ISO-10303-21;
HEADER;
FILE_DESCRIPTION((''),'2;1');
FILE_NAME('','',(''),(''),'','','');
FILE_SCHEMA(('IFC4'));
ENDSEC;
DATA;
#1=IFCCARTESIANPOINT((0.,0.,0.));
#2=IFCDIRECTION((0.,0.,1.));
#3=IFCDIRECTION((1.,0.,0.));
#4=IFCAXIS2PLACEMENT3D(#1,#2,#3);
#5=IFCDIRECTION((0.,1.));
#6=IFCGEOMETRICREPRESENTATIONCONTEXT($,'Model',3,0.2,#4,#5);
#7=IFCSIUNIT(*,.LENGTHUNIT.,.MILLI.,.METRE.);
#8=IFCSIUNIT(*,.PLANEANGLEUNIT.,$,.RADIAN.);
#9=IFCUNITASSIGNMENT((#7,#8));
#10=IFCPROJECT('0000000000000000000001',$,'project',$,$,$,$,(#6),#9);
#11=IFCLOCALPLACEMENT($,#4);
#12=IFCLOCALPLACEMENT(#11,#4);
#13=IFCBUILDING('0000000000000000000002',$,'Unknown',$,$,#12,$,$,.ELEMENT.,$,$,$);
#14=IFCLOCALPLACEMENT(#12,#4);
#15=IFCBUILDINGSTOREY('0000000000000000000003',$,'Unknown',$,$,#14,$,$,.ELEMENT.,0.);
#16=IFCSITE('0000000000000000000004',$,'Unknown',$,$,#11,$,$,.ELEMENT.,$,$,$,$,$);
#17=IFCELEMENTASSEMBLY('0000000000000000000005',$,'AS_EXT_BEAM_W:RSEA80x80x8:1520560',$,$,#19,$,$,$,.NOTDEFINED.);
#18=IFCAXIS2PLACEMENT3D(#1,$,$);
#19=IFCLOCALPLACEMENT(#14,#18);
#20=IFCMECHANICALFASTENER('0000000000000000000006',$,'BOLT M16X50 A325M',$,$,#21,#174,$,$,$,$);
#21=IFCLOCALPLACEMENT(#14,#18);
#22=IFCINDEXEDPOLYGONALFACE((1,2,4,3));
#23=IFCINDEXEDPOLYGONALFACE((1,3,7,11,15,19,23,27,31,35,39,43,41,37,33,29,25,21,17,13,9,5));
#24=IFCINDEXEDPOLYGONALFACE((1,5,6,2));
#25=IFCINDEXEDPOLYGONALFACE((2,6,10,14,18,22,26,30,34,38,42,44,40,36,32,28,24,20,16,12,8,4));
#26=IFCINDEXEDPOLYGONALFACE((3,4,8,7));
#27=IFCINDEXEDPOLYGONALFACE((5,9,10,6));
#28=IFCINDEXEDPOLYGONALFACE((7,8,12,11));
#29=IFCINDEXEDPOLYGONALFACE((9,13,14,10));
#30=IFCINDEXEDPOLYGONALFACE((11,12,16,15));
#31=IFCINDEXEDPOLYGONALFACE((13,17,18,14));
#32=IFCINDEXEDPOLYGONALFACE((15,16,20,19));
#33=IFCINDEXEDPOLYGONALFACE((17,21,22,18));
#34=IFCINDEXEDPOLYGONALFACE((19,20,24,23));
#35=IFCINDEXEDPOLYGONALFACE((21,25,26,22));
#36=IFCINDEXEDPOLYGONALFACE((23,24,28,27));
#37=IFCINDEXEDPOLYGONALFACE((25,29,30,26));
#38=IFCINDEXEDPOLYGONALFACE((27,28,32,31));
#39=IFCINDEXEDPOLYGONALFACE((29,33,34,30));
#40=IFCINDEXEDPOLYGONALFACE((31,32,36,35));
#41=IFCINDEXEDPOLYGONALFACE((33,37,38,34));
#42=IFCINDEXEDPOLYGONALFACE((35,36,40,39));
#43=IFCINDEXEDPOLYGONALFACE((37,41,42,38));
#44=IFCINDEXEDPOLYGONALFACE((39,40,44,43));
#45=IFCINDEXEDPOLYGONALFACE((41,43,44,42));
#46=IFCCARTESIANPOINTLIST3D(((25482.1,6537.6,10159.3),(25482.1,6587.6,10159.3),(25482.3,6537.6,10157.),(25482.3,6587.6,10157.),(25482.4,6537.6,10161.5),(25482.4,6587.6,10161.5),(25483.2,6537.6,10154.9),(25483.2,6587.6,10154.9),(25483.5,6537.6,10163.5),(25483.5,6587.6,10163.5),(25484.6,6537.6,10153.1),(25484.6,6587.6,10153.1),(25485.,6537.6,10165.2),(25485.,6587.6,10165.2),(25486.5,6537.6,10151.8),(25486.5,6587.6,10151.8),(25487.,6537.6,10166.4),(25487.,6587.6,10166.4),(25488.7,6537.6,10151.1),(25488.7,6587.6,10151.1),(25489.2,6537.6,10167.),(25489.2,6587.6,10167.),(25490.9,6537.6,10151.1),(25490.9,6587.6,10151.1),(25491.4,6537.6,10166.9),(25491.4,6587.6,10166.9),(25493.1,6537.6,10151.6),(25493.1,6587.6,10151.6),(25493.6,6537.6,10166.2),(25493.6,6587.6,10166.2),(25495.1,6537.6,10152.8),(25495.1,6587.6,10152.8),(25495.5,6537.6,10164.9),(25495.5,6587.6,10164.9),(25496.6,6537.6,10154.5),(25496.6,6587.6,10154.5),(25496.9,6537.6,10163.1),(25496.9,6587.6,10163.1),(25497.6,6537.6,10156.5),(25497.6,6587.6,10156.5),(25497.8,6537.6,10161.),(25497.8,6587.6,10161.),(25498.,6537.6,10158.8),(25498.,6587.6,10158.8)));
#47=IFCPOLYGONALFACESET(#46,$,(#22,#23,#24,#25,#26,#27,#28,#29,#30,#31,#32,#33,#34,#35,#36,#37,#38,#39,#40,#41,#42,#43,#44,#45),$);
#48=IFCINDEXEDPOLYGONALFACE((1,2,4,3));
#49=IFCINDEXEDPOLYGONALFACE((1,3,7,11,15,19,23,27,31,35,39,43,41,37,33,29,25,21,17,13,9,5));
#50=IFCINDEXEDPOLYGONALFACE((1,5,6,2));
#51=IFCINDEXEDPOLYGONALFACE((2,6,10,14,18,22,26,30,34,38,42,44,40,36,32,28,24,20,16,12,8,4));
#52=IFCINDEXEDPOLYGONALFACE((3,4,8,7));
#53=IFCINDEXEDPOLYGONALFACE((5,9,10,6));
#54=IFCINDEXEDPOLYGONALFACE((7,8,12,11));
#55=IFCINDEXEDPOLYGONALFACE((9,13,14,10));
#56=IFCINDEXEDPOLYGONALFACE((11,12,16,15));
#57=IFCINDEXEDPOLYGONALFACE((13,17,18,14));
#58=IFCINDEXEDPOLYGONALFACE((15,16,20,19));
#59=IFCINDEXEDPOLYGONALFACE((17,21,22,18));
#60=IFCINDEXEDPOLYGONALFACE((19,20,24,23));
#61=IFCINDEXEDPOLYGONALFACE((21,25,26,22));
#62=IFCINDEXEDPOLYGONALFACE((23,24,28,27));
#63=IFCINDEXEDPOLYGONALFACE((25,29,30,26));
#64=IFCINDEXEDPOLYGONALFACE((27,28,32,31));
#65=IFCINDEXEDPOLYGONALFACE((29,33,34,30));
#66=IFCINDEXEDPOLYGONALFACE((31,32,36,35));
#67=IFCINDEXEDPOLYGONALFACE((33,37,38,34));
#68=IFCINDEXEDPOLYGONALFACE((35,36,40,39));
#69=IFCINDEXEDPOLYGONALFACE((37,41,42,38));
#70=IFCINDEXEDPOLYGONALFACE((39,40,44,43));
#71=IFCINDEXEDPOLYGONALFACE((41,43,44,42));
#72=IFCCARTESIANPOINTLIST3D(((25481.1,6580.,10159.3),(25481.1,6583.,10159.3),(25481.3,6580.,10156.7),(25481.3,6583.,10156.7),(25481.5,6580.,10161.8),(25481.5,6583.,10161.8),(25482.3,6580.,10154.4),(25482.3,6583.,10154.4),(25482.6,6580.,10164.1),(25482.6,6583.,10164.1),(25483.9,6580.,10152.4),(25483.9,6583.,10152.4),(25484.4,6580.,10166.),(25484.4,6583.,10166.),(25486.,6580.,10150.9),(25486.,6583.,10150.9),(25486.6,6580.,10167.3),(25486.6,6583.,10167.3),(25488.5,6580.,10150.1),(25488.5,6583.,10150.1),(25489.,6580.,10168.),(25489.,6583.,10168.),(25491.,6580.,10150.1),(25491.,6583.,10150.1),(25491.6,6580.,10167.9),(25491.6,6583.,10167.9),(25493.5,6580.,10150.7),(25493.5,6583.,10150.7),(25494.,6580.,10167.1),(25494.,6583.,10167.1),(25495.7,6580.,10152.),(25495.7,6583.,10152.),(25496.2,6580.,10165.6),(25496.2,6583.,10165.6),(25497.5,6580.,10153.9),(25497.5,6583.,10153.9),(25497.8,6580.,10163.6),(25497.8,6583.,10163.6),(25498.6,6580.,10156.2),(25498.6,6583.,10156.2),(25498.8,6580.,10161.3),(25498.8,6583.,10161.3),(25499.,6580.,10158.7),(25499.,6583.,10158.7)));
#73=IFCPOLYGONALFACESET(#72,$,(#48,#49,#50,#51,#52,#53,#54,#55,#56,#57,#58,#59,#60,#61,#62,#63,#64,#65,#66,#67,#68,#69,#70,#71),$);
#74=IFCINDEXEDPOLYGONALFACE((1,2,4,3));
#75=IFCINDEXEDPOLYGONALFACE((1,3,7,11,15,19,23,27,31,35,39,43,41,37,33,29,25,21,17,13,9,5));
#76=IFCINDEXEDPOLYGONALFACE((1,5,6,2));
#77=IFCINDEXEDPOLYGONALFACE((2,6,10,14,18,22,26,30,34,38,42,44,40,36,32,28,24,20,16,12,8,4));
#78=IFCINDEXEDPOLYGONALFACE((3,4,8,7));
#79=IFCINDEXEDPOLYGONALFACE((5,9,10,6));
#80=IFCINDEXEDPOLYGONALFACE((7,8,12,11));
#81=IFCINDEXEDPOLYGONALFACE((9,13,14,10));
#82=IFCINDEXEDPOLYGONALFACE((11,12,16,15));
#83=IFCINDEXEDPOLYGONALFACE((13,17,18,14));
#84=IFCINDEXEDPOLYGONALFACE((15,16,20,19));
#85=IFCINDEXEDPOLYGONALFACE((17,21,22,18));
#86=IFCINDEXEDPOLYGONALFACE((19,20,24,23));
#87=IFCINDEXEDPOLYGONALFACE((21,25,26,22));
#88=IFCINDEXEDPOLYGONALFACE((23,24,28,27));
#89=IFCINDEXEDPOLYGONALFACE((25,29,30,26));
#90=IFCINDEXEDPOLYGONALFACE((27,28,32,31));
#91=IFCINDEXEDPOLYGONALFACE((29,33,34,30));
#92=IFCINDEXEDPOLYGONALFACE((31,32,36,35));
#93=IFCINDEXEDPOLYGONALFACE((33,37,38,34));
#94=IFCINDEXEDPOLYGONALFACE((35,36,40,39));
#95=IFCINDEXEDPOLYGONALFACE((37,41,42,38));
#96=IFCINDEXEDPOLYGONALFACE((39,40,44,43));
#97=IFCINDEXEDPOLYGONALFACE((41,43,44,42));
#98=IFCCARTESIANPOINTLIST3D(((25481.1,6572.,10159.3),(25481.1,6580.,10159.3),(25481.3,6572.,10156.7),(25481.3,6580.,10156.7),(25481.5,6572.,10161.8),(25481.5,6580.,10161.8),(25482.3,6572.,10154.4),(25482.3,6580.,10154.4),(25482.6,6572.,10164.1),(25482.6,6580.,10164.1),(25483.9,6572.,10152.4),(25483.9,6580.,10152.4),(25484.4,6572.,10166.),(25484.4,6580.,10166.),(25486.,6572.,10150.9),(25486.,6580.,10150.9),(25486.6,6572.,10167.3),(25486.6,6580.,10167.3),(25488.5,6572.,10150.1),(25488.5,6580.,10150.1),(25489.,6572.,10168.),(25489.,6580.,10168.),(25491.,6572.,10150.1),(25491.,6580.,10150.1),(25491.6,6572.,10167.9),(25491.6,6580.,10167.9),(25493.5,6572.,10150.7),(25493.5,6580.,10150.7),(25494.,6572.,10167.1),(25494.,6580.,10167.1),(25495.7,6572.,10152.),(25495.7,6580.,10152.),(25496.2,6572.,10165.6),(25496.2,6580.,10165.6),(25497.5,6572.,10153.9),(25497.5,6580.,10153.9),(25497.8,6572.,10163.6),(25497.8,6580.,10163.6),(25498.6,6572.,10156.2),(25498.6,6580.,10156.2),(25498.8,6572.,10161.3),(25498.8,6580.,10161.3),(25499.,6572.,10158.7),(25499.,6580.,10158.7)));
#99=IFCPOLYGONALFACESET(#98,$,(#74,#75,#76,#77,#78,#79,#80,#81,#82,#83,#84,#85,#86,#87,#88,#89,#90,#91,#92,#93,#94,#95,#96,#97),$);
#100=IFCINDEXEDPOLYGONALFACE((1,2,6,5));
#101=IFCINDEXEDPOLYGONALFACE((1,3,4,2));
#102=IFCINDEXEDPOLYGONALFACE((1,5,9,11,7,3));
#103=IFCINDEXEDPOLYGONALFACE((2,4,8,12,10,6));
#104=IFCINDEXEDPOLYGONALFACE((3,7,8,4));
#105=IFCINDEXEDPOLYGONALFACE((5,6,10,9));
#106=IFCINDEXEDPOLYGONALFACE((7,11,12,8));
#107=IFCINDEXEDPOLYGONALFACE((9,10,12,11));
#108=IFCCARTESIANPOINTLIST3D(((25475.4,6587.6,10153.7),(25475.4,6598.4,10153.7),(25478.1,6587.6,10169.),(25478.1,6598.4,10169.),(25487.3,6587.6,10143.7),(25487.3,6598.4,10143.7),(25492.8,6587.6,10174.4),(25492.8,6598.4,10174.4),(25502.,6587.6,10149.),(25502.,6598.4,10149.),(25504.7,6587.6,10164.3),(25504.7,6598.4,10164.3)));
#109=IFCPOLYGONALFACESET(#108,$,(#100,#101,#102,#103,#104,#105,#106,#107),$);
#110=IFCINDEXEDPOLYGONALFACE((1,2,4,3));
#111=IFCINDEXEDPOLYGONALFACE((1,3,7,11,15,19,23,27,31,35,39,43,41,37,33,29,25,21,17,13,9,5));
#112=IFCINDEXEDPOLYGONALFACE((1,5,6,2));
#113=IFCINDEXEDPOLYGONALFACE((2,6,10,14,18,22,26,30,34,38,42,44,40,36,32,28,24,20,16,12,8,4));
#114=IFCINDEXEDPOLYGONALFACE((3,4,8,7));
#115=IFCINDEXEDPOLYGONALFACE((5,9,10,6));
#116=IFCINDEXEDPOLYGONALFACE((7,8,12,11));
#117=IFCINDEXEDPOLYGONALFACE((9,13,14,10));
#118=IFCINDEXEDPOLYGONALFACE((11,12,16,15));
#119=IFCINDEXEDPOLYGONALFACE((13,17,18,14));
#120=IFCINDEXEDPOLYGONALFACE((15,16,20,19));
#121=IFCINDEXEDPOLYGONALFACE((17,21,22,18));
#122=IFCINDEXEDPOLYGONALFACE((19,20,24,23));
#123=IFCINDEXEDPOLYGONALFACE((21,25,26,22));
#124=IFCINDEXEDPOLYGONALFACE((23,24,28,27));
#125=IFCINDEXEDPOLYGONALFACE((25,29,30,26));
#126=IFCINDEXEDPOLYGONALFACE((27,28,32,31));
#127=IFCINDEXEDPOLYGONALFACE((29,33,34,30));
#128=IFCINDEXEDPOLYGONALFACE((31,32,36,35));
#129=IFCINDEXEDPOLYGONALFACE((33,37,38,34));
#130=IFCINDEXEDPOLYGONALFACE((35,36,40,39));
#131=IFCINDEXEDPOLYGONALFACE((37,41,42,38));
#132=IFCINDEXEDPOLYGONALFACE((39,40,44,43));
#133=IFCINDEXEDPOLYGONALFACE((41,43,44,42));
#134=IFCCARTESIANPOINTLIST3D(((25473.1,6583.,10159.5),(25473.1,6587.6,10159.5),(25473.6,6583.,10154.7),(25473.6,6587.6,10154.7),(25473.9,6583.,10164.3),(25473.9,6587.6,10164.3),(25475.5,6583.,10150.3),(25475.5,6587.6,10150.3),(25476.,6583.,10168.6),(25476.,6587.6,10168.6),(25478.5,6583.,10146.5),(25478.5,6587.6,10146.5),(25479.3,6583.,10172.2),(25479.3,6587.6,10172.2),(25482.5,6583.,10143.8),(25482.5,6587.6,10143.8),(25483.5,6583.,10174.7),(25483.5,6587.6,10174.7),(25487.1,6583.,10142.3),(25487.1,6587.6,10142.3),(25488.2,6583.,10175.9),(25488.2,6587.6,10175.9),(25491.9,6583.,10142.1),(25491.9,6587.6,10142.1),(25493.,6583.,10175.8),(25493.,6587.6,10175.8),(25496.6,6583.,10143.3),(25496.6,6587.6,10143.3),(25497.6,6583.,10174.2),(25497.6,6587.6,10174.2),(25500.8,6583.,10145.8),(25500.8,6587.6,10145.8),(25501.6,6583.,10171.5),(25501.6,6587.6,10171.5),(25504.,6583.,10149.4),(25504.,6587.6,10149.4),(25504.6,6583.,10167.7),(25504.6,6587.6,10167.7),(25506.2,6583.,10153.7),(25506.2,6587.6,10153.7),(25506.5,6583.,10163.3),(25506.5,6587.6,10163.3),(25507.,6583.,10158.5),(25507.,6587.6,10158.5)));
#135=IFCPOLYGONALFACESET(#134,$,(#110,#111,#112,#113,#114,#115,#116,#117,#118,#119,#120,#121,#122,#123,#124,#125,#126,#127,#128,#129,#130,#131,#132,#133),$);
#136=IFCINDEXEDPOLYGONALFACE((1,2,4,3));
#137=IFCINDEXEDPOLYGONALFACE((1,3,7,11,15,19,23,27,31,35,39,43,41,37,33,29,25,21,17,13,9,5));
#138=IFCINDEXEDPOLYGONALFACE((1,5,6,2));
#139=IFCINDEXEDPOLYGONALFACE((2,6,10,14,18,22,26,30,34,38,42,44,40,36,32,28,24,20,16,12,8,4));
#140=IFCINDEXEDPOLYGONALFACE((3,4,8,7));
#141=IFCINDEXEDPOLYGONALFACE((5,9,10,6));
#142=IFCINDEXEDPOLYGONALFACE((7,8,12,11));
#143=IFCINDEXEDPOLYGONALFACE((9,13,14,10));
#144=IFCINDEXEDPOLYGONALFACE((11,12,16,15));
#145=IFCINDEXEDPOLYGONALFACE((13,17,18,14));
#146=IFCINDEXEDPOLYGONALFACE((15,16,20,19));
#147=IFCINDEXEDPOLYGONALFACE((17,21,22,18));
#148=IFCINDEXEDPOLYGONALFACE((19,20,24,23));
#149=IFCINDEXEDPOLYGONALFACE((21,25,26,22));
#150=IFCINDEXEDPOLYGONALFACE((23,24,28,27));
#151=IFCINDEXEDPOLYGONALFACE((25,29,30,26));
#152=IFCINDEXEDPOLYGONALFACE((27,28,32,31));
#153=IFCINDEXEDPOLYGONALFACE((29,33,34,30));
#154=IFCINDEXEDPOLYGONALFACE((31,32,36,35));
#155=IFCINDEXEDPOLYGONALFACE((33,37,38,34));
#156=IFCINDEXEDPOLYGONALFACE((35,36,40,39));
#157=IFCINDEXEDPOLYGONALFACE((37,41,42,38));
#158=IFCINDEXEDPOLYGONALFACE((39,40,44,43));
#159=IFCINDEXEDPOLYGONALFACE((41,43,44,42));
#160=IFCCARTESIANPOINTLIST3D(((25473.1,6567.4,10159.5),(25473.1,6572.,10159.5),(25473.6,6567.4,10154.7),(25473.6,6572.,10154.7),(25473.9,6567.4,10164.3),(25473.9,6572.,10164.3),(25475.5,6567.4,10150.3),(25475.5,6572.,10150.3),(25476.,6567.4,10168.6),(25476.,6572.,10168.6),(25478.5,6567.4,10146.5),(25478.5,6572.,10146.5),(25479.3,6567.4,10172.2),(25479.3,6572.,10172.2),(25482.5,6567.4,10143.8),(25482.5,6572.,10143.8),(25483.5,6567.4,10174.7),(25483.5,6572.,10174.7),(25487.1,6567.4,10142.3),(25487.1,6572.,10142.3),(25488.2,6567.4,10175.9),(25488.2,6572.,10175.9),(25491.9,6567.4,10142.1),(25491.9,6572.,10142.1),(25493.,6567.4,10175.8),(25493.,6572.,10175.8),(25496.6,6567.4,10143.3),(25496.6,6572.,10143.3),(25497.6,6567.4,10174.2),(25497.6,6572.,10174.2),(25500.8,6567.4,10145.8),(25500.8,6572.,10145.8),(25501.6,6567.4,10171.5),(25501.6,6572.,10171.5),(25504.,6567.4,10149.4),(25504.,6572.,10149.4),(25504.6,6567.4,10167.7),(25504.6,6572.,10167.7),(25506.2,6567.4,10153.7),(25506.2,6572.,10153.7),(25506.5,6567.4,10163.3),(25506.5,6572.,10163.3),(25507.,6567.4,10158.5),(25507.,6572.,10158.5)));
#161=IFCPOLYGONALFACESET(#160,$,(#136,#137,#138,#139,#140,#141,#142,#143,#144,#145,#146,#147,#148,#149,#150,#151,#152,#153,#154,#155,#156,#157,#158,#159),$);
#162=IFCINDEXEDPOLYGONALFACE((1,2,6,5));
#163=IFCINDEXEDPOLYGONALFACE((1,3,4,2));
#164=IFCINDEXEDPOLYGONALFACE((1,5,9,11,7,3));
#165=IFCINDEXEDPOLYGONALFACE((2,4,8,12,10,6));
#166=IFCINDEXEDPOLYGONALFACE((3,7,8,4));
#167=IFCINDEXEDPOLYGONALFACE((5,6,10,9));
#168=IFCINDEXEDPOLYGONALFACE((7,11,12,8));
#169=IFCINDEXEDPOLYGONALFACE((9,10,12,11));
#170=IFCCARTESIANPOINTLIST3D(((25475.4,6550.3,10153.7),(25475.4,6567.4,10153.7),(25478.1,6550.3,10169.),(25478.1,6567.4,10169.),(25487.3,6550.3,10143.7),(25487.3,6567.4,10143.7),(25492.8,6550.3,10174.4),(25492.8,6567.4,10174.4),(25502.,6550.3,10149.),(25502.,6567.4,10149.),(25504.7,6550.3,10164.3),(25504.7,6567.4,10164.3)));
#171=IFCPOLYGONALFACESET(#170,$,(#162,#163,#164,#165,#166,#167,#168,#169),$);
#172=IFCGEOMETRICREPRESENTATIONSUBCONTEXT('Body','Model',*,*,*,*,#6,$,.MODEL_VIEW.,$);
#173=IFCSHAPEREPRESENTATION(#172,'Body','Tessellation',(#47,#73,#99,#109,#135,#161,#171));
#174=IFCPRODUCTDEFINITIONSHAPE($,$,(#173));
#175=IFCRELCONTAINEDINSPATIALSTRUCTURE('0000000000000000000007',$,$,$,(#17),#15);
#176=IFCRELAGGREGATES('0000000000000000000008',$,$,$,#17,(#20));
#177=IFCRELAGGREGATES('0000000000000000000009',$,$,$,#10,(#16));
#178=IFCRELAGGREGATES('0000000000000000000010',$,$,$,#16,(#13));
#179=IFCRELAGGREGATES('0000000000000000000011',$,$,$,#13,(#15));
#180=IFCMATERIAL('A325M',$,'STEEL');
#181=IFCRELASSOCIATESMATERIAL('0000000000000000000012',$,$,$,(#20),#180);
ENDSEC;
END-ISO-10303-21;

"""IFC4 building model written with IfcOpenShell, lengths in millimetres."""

from ifc_helpers import new_model, si_unit, direction, frame, origin_with_axes, place, context, subcontext, project, spatial, line, arc, indexed_curve, outline, extrude, source, transform, mapped, material, element, aggregate, save


model = new_model("IFC4")

# Units and contexts
model_context = context("Model", 3, precision=0.2, world=origin_with_axes(), true_north=direction((0.0, 1.0)))
body_context = subcontext(model_context, "Body", "Model", "MODEL_VIEW")
ifc_project = project(units=[si_unit("LENGTHUNIT", "METRE", prefix="MILLI"), si_unit("PLANEANGLEUNIT", "RADIAN")], contexts=[model_context])

# Site, building, storey
site_placement = place(None, origin_with_axes())
site = spatial("IfcSite", under=ifc_project, at=site_placement, Name="Unknown", CompositionType="ELEMENT")
building_placement = place(site_placement, origin_with_axes())
building = spatial("IfcBuilding", under=site, at=building_placement, Name="Unknown", CompositionType="ELEMENT")
storey_placement = place(building_placement, origin_with_axes())
storey = spatial("IfcBuildingStorey", under=building, at=storey_placement, Name="Unknown", CompositionType="ELEMENT", Elevation=0.0)

# Element assembly
assembly_1_placement = place(storey_placement, frame((25427.6, 6540.0, 10164.9), z_axis=(0.0, -1.0, 0.0), x_axis=(0.984808, 0.0, -0.173648)))
assembly_1 = element("IfcElementAssembly", 1, at=assembly_1_placement, inside=storey, Name="AS_EXT_BEAM_W:RSEA80x80x8:1520560", PredefinedType="NOTDEFINED")

# Mechanical fastener
ifc_material_1 = material(Name="A325M", Category="STEEL")
shared_shape_1 = source(origin_with_axes(), body_context, "Body", "SweptSolid", [
    extrude(outline(indexed_curve([(8.0, 0.0), (0.0, 8.0), (-8.0, 0.0), (0.0, -8.0)], segments=[arc(1, 2, 3), arc(3, 4, 1)])), frame((0.0, 0.0, 15.6), z_axis=(0.0, 0.0, -1.0), x_axis=(0.0, 1.0, 0.0)), (0.0, 0.0, 1.0), 50.0),
    extrude(outline(indexed_curve([(9.0, 0.0), (0.0, 9.0), (-9.0, 0.0), (0.0, -9.0)], segments=[arc(1, 2, 3), arc(3, 4, 1)])), frame((0.0, 0.0, 11.0), z_axis=(0.0, 0.0, -1.0), x_axis=(0.0, 1.0, 0.0)), (0.0, 0.0, 1.0), 3.0),
    extrude(outline(indexed_curve([(9.0, 0.0), (0.0, 9.0), (-9.0, 0.0), (0.0, -9.0)], segments=[arc(1, 2, 3), arc(3, 4, 1)])), frame((0.0, 0.0, 8.0), z_axis=(0.0, 0.0, -1.0), x_axis=(0.0, 1.0, 0.0)), (0.0, 0.0, 1.0), 8.0),
    extrude(outline(indexed_curve([(15.6, 0.0), (7.8, 13.5), (-7.8, 13.5), (-15.6, 0.0), (-7.8, -13.5), (7.8, -13.5)], segments=[line(1, 2, 3, 4, 5, 6, 1)])), frame((0.0, 0.0, 26.4), z_axis=(0.0, 0.0, -1.0), x_axis=(0.0, 1.0, 0.0)), (0.0, 0.0, 1.0), 10.8),
    extrude(outline(indexed_curve([(17.0, 0.0), (0.0, 17.0), (-17.0, 0.0), (0.0, -17.0)], segments=[arc(1, 2, 3), arc(3, 4, 1)])), frame((0.0, 0.0, 15.6), z_axis=(0.0, 0.0, -1.0), x_axis=(0.0, 1.0, 0.0)), (0.0, 0.0, 1.0), 4.6),
    extrude(outline(indexed_curve([(17.0, 0.0), (0.0, 17.0), (-17.0, 0.0), (0.0, -17.0)], segments=[arc(1, 2, 3), arc(3, 4, 1)])), frame((0.0, 0.0, 0.0), z_axis=(0.0, 0.0, -1.0), x_axis=(0.0, 1.0, 0.0)), (0.0, 0.0, 1.0), 4.6),
    extrude(outline(indexed_curve([(15.6, 0.0), (7.8, 13.5), (-7.8, 13.5), (-15.6, 0.0), (-7.8, -13.5), (7.8, -13.5)], segments=[line(1, 2, 3, 4, 5, 6, 1)])), frame((0.0, 0.0, -4.6), z_axis=(0.0, 0.0, -1.0), x_axis=(0.0, 1.0, 0.0)), (0.0, 0.0, 1.0), 17.1),
])
mechanical_fastener_1_placement = place(assembly_1_placement, frame((62.5, 5.0, -32.0), z_axis=(0.0, 0.0, -1.0), x_axis=(1.0, 0.0, 0.0)))
mechanical_fastener_1 = element("IfcMechanicalFastener", 2, at=mechanical_fastener_1_placement, material=ifc_material_1, Name="BOLT M16X50 A325M", context=body_context, shape_type="MappedRepresentation", body=[
    mapped(shared_shape_1, transform((0.0, 0.0, 0.0))),
])
aggregate(assembly_1, [mechanical_fastener_1])

save(model, "model.ifc")
